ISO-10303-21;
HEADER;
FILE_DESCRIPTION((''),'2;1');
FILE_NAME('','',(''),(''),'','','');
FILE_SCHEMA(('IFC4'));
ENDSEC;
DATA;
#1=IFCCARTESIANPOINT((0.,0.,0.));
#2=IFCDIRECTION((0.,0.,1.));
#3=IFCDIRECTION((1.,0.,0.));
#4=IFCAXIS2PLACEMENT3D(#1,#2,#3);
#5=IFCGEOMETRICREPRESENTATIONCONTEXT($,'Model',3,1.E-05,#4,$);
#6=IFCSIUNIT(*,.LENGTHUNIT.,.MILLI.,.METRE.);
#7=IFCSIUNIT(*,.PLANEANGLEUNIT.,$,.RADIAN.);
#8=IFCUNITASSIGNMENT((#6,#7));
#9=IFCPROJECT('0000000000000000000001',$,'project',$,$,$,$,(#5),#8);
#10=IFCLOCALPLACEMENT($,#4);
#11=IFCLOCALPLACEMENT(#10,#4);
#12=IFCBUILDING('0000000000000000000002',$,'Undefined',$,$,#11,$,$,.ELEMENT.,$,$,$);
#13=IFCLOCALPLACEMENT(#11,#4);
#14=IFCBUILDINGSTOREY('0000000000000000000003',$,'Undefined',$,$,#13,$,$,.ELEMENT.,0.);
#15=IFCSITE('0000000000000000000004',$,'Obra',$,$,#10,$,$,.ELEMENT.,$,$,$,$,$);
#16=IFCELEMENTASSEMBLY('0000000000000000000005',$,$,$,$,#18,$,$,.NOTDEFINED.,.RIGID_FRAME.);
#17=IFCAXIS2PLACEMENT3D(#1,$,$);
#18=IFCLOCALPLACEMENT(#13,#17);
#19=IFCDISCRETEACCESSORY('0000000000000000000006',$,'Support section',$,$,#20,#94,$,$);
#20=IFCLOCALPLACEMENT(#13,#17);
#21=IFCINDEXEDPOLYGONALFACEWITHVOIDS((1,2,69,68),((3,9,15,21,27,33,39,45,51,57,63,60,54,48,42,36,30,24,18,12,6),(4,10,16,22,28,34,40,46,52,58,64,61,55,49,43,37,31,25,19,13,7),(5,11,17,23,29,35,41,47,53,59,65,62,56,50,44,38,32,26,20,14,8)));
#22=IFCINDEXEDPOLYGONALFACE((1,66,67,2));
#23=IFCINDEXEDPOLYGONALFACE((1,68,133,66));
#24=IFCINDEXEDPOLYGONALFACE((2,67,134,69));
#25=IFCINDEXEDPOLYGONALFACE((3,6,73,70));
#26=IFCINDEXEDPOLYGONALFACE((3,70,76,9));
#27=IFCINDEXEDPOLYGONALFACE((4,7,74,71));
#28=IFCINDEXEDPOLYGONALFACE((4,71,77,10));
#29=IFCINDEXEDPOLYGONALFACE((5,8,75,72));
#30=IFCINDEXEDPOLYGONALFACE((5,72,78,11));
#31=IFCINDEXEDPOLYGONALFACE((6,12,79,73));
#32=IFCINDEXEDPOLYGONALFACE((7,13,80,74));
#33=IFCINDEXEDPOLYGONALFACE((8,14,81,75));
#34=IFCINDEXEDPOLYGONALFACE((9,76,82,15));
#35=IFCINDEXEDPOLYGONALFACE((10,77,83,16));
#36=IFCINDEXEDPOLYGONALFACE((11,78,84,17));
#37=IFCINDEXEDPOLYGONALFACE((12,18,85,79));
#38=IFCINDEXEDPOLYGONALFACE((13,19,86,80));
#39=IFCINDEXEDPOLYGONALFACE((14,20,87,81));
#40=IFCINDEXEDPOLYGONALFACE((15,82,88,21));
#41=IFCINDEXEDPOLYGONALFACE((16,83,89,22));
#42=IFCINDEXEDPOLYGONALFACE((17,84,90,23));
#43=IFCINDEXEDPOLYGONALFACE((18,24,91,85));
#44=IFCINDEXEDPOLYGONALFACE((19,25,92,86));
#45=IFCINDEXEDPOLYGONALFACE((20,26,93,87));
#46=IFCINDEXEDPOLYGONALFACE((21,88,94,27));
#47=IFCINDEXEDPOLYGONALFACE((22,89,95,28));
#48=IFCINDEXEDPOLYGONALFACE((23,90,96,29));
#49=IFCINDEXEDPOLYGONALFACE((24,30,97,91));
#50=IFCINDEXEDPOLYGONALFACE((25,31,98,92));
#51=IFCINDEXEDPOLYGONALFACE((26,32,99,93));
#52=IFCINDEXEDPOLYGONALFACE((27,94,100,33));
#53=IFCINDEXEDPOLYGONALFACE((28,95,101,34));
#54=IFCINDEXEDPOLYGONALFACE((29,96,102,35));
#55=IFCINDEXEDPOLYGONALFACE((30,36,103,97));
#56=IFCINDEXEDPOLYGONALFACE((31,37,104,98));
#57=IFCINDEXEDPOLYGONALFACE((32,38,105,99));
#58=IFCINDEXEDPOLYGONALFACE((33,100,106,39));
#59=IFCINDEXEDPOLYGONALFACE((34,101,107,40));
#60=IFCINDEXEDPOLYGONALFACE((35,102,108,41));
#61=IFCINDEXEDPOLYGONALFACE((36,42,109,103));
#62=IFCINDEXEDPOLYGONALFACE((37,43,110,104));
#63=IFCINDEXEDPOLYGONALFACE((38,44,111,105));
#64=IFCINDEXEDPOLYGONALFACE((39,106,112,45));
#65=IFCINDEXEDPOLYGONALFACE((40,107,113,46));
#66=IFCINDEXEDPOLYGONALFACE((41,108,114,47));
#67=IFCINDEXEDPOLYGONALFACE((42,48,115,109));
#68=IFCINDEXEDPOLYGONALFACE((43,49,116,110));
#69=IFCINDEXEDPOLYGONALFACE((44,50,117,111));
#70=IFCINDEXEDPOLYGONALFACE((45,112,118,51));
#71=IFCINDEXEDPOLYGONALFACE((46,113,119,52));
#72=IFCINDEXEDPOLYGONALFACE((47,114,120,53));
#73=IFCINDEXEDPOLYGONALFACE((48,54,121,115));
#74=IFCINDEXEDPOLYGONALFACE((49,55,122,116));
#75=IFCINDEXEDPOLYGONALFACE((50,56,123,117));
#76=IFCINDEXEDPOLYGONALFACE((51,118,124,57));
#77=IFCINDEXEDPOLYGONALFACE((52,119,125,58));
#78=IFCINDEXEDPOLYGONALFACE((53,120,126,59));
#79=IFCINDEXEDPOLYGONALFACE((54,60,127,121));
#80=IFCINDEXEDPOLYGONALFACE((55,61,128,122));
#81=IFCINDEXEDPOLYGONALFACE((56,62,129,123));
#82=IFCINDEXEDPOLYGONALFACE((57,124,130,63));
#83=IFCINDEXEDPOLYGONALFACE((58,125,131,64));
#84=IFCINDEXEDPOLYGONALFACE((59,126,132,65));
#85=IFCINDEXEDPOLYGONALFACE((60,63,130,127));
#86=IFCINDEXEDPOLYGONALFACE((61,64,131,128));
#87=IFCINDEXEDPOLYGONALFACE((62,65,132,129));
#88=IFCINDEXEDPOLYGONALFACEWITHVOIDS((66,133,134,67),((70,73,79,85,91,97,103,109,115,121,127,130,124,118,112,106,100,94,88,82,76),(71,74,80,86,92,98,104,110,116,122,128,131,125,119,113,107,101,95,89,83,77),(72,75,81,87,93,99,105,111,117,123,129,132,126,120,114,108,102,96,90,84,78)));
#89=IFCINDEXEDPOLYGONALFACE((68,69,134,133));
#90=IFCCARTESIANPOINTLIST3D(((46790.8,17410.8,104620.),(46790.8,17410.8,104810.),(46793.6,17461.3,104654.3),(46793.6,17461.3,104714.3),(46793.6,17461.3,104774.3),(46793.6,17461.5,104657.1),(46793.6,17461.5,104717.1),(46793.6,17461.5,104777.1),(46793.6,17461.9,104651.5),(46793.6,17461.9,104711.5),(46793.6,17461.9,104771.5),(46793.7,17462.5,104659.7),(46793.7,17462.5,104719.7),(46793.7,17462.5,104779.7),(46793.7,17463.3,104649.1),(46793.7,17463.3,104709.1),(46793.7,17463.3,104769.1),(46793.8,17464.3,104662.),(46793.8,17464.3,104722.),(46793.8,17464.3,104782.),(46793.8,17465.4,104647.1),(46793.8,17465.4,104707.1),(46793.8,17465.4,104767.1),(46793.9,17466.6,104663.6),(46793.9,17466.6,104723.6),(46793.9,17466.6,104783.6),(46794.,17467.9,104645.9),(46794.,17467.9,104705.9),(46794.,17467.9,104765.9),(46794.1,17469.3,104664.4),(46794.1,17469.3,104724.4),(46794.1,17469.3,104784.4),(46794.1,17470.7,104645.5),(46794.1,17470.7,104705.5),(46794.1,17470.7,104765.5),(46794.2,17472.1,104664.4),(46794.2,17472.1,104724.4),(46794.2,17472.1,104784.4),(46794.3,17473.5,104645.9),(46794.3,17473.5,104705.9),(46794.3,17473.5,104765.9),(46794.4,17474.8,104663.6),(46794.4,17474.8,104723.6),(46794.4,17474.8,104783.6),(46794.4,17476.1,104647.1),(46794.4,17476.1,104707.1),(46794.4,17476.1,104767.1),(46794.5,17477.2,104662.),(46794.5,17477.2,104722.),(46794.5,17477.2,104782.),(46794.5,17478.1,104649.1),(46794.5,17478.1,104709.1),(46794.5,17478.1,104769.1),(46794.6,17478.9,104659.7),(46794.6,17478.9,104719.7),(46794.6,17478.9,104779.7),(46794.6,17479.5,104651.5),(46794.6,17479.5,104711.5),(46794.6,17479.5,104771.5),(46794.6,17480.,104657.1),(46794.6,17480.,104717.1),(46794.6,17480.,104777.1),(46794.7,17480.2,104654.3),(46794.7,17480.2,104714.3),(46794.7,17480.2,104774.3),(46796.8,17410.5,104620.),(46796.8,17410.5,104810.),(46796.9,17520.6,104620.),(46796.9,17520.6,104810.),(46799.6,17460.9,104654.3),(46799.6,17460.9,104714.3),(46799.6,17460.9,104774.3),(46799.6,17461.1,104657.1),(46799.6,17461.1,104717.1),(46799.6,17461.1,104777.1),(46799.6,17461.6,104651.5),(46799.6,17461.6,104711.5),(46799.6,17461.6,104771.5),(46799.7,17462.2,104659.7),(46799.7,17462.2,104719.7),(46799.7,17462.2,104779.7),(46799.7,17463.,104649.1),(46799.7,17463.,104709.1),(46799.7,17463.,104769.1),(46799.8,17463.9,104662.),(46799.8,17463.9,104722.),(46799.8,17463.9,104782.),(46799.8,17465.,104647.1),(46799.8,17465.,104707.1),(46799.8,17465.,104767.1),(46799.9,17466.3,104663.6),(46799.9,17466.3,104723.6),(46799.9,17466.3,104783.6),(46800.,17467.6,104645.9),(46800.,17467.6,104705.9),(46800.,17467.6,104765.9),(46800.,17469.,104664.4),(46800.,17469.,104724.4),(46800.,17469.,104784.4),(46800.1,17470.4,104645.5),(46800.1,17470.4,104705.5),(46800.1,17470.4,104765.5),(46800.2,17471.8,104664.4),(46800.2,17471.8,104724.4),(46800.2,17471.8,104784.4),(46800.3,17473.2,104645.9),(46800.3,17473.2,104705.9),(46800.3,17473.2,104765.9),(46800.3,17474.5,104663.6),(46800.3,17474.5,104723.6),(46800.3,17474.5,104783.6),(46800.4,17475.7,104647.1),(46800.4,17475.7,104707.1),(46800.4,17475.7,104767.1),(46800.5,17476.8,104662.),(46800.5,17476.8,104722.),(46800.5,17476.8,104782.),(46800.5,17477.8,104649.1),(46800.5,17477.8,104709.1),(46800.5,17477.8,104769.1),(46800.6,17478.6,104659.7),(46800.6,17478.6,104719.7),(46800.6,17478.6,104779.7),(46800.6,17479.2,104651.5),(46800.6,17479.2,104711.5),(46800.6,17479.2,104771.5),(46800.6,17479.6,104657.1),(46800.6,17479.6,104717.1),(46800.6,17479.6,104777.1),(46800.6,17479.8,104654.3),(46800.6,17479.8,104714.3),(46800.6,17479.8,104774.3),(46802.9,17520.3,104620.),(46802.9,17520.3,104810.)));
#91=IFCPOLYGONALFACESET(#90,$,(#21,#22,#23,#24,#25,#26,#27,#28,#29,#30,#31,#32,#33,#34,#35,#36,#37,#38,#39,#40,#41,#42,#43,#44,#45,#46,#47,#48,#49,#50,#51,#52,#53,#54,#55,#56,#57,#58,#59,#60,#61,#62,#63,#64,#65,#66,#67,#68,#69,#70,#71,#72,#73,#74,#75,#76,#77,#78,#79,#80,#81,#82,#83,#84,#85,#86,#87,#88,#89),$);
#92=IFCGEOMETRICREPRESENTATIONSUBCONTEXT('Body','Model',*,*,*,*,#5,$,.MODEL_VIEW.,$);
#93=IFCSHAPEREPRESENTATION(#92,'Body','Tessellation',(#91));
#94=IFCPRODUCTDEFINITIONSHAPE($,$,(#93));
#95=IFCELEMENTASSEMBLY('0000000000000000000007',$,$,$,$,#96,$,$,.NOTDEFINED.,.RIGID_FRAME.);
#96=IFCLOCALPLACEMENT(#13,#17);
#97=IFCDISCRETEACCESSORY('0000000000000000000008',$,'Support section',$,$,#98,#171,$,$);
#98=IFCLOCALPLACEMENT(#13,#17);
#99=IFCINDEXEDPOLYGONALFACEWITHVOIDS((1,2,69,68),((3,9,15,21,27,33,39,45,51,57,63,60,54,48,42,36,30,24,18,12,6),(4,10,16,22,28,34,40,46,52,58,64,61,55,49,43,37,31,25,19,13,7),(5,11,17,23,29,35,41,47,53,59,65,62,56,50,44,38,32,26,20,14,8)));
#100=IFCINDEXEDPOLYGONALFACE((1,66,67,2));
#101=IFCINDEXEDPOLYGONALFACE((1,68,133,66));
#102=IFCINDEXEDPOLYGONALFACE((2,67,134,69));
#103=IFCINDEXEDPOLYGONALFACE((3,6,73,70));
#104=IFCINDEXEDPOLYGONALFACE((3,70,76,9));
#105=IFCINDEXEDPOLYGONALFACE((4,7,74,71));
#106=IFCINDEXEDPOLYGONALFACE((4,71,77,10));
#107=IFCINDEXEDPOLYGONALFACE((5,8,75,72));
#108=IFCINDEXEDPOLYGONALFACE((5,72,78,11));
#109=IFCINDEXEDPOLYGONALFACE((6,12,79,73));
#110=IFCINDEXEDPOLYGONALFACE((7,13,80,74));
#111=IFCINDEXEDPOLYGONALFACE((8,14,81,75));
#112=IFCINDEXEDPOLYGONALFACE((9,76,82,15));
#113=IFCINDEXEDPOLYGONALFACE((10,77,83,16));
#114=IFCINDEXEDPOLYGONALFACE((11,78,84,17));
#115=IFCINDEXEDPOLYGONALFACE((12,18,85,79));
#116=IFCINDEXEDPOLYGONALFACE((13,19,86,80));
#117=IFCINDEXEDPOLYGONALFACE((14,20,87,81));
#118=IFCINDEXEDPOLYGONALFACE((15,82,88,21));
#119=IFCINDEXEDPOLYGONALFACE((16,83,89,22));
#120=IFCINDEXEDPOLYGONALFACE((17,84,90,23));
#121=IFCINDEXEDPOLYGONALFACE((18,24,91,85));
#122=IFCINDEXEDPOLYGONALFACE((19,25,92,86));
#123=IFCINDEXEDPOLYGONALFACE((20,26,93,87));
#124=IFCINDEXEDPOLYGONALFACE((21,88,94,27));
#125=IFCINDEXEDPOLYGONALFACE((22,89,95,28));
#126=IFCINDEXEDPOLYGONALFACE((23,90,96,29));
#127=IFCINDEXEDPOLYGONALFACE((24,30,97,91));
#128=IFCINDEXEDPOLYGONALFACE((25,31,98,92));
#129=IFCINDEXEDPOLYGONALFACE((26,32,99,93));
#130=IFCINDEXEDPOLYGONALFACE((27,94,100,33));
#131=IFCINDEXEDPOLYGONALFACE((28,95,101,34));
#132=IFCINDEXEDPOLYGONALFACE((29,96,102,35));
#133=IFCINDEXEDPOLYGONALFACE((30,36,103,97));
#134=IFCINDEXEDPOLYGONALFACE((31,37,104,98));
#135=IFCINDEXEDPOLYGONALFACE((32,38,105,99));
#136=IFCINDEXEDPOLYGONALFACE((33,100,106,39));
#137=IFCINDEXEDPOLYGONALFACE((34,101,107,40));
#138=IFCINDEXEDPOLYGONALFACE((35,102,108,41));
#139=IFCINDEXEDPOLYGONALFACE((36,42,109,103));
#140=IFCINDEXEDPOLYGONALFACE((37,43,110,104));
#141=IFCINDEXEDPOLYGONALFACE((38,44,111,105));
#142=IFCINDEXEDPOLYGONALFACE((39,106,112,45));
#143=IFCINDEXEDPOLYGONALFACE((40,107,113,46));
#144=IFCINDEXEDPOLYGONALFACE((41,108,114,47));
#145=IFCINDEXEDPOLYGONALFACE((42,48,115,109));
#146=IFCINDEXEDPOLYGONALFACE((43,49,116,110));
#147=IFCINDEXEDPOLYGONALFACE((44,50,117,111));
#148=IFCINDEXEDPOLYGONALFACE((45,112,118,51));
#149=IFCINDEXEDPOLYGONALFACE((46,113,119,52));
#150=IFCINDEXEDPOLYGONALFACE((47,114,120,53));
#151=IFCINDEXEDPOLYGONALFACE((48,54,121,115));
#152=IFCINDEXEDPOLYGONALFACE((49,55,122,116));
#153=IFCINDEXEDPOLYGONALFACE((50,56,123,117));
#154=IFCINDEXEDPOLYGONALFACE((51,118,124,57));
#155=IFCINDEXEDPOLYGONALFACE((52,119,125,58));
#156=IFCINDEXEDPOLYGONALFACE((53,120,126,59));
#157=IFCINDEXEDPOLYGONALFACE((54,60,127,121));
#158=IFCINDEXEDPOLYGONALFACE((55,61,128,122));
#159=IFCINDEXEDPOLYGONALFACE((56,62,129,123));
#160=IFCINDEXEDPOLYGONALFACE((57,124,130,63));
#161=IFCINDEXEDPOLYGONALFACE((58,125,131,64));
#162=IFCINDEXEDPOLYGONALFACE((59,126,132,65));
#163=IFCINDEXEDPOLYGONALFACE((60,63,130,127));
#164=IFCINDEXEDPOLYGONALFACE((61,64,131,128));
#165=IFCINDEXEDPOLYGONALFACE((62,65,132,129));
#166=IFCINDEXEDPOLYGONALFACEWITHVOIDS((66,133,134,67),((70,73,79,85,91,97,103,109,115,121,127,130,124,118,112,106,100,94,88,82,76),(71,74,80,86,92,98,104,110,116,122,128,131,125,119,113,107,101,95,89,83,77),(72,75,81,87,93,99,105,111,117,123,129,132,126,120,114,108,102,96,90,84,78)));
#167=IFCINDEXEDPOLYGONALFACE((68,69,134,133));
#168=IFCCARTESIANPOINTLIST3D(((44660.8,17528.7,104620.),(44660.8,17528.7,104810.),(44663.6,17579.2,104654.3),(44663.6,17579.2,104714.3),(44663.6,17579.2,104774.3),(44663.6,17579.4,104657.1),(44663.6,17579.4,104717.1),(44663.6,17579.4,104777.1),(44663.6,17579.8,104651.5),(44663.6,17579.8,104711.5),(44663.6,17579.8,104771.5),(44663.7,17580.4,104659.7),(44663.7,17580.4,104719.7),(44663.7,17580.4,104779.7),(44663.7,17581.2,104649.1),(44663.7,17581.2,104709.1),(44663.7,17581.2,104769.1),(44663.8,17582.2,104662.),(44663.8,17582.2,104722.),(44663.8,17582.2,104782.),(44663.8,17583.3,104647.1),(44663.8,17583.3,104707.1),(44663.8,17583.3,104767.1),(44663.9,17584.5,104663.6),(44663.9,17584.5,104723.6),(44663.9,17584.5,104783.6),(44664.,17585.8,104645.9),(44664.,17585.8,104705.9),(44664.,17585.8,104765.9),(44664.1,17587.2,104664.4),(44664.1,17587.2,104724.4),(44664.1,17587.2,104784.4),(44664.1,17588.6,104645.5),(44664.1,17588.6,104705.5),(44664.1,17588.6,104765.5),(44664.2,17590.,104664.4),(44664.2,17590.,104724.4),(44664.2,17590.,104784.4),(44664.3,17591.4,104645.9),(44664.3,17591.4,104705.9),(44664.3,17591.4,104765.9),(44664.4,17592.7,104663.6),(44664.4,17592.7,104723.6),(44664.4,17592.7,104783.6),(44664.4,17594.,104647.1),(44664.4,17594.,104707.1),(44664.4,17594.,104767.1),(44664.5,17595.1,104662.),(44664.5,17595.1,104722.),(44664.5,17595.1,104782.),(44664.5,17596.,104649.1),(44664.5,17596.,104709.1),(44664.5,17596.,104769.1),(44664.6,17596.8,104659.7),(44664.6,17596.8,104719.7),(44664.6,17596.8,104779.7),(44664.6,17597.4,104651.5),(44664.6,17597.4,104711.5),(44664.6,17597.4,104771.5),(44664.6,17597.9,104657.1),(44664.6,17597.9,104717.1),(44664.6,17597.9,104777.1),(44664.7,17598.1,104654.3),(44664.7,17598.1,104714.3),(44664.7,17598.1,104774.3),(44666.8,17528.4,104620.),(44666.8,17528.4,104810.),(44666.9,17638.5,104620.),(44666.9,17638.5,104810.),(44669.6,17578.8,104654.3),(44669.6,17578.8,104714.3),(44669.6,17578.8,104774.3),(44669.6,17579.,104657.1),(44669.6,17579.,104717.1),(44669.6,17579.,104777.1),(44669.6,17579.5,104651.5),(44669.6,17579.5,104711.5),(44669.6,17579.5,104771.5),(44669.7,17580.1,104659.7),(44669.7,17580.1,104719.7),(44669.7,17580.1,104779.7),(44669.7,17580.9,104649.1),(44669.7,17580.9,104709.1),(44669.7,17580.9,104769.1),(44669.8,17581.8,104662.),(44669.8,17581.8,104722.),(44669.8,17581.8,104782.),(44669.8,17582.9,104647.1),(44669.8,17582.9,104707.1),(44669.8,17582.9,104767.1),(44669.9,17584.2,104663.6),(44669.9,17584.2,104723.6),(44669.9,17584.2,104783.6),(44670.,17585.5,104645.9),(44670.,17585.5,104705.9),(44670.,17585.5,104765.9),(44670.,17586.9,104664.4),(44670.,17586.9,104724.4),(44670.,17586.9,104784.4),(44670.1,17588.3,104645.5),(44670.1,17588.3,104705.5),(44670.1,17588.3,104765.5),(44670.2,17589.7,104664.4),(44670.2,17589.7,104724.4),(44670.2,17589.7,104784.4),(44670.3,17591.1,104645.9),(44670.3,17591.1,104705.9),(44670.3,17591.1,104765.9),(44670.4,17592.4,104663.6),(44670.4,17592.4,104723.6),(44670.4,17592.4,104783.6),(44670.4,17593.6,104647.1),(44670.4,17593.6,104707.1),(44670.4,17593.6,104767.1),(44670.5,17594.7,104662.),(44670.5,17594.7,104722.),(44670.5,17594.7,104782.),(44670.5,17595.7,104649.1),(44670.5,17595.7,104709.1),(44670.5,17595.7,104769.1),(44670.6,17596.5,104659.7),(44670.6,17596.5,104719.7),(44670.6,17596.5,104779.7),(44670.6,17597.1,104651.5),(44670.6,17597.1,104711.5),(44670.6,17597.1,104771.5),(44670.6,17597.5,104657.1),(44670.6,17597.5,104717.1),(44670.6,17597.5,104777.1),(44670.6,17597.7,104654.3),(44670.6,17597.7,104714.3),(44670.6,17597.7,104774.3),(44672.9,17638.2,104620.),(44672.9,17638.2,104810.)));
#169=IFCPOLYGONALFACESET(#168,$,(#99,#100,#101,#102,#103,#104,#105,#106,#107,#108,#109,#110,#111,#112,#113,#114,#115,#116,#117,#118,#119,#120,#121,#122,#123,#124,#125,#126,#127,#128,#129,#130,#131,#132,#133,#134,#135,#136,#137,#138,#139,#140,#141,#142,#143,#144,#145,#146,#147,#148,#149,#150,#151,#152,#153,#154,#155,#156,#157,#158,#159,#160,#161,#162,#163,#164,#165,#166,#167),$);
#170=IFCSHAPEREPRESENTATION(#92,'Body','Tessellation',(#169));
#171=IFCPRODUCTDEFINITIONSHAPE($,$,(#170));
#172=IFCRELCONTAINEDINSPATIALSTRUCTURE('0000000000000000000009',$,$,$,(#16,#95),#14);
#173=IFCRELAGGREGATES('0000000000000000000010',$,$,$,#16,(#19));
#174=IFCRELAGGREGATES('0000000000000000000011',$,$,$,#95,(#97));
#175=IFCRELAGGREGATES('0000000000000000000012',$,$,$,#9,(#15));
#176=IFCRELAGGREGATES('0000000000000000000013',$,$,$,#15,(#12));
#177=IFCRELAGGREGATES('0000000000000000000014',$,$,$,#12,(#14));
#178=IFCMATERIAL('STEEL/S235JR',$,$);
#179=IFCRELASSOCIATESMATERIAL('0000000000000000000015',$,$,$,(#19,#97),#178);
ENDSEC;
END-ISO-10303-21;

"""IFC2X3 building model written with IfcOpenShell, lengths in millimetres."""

from ifc_helpers import new_model, si_unit, frame, origin_with_axes, origin_2d_with_axis, place, context, subcontext, project, spatial, rectangle, circle, extrude, source, transform, mapped, material, element, aggregate, save


model = new_model("IFC2X3")

# Units and contexts
model_context = context("Model", 3, precision=1e-05, world=origin_with_axes())
body_context = subcontext(model_context, "Body", "Model", "MODEL_VIEW")
ifc_project = project(units=[si_unit("LENGTHUNIT", "METRE", prefix="MILLI"), si_unit("PLANEANGLEUNIT", "RADIAN")], contexts=[model_context])

# Site, building, storey
site_placement = place(None, origin_with_axes())
site = spatial("IfcSite", under=ifc_project, at=site_placement, Name="Obra", CompositionType="ELEMENT")
building_placement = place(site_placement, origin_with_axes())
building = spatial("IfcBuilding", under=site, at=building_placement, Name="Undefined", CompositionType="ELEMENT")
storey_placement = place(building_placement, origin_with_axes())
storey = spatial("IfcBuildingStorey", under=building, at=storey_placement, Name="Undefined", CompositionType="ELEMENT", Elevation=0.0)

# Shared definitions
ifc_material = material(Name="STEEL/S235JR")

# Element assemblies, discrete accessories, openings
shared_shape_1 = source(origin_with_axes(), body_context, "Body", "SweptSolid", [
    extrude(circle(Radius=9.5, at=origin_2d_with_axis()), frame((0.0, -9.2, 0.0), z_axis=(0.0, 1.0, 0.0), x_axis=(1.0, 0.0, 0.0)), (0.0, 0.0, 1.0), 6.2),
])
assembly_1_placement = place(storey_placement, origin_with_axes())
assembly_1 = element("IfcElementAssembly", 1, at=assembly_1_placement, inside=storey, AssemblyPlace="NOTDEFINED", PredefinedType="RIGID_FRAME")
discrete_accessory_1_placement = place(assembly_1_placement, frame((46796.9, 17465.6, 104620.0), z_axis=(0.0, 0.0, 1.0), x_axis=(-0.055268, -0.998472, 0.0)))
discrete_accessory_1 = element("IfcDiscreteAccessory", 2, at=discrete_accessory_1_placement, material=ifc_material, Name="Support section", context=body_context, shape_type="SweptSolid", body=[
    extrude(rectangle(XDim=6.0, YDim=110.0, at=origin_2d_with_axis()), frame((0.0, 0.0, 190.0), z_axis=(0.0, 0.0, -1.0), x_axis=(0.0, 1.0, 0.0)), (0.0, 0.0, 1.0), 190.0),
])
opening_1_placement = place(assembly_1_placement, frame((46788.3, 17421.0, 104835.0), z_axis=(0.055268, 0.998472, 0.0), x_axis=(0.0, 0.0, -1.0)))
element("IfcOpeningElement", 3, at=opening_1_placement, cuts=discrete_accessory_1, ObjectType="Opening", context=body_context, shape_type="MappedRepresentation", body=[
    mapped(shared_shape_1, transform((60.0, 0.0, 50.0))),
    mapped(shared_shape_1, transform((120.0, 0.0, 50.0))),
    mapped(shared_shape_1, transform((180.0, 0.0, 50.0))),
])
aggregate(assembly_1, [discrete_accessory_1])
assembly_2_placement = place(storey_placement, origin_with_axes())
assembly_2 = element("IfcElementAssembly", 4, at=assembly_2_placement, inside=storey, AssemblyPlace="NOTDEFINED", PredefinedType="RIGID_FRAME")
discrete_accessory_2_placement = place(assembly_2_placement, frame((44666.9, 17583.5, 104620.0), z_axis=(0.0, 0.0, 1.0), x_axis=(-0.055268, -0.998472, 0.0)))
discrete_accessory_2 = element("IfcDiscreteAccessory", 5, at=discrete_accessory_2_placement, material=ifc_material, Name="Support section", context=body_context, shape_type="SweptSolid", body=[
    extrude(rectangle(XDim=6.0, YDim=110.0, at=origin_2d_with_axis()), frame((0.0, 0.0, 190.0), z_axis=(0.0, 0.0, -1.0), x_axis=(0.0, 1.0, 0.0)), (0.0, 0.0, 1.0), 190.0),
])
opening_2_placement = place(assembly_2_placement, frame((44658.3, 17538.9, 104835.0), z_axis=(0.055268, 0.998472, 0.0), x_axis=(0.0, 0.0, -1.0)))
element("IfcOpeningElement", 6, at=opening_2_placement, cuts=discrete_accessory_2, ObjectType="Opening", context=body_context, shape_type="MappedRepresentation", body=[
    mapped(shared_shape_1, transform((60.0, 0.0, 50.0))),
    mapped(shared_shape_1, transform((120.0, 0.0, 50.0))),
    mapped(shared_shape_1, transform((180.0, 0.0, 50.0))),
])
aggregate(assembly_2, [discrete_accessory_2])

save(model, "model.ifc")
